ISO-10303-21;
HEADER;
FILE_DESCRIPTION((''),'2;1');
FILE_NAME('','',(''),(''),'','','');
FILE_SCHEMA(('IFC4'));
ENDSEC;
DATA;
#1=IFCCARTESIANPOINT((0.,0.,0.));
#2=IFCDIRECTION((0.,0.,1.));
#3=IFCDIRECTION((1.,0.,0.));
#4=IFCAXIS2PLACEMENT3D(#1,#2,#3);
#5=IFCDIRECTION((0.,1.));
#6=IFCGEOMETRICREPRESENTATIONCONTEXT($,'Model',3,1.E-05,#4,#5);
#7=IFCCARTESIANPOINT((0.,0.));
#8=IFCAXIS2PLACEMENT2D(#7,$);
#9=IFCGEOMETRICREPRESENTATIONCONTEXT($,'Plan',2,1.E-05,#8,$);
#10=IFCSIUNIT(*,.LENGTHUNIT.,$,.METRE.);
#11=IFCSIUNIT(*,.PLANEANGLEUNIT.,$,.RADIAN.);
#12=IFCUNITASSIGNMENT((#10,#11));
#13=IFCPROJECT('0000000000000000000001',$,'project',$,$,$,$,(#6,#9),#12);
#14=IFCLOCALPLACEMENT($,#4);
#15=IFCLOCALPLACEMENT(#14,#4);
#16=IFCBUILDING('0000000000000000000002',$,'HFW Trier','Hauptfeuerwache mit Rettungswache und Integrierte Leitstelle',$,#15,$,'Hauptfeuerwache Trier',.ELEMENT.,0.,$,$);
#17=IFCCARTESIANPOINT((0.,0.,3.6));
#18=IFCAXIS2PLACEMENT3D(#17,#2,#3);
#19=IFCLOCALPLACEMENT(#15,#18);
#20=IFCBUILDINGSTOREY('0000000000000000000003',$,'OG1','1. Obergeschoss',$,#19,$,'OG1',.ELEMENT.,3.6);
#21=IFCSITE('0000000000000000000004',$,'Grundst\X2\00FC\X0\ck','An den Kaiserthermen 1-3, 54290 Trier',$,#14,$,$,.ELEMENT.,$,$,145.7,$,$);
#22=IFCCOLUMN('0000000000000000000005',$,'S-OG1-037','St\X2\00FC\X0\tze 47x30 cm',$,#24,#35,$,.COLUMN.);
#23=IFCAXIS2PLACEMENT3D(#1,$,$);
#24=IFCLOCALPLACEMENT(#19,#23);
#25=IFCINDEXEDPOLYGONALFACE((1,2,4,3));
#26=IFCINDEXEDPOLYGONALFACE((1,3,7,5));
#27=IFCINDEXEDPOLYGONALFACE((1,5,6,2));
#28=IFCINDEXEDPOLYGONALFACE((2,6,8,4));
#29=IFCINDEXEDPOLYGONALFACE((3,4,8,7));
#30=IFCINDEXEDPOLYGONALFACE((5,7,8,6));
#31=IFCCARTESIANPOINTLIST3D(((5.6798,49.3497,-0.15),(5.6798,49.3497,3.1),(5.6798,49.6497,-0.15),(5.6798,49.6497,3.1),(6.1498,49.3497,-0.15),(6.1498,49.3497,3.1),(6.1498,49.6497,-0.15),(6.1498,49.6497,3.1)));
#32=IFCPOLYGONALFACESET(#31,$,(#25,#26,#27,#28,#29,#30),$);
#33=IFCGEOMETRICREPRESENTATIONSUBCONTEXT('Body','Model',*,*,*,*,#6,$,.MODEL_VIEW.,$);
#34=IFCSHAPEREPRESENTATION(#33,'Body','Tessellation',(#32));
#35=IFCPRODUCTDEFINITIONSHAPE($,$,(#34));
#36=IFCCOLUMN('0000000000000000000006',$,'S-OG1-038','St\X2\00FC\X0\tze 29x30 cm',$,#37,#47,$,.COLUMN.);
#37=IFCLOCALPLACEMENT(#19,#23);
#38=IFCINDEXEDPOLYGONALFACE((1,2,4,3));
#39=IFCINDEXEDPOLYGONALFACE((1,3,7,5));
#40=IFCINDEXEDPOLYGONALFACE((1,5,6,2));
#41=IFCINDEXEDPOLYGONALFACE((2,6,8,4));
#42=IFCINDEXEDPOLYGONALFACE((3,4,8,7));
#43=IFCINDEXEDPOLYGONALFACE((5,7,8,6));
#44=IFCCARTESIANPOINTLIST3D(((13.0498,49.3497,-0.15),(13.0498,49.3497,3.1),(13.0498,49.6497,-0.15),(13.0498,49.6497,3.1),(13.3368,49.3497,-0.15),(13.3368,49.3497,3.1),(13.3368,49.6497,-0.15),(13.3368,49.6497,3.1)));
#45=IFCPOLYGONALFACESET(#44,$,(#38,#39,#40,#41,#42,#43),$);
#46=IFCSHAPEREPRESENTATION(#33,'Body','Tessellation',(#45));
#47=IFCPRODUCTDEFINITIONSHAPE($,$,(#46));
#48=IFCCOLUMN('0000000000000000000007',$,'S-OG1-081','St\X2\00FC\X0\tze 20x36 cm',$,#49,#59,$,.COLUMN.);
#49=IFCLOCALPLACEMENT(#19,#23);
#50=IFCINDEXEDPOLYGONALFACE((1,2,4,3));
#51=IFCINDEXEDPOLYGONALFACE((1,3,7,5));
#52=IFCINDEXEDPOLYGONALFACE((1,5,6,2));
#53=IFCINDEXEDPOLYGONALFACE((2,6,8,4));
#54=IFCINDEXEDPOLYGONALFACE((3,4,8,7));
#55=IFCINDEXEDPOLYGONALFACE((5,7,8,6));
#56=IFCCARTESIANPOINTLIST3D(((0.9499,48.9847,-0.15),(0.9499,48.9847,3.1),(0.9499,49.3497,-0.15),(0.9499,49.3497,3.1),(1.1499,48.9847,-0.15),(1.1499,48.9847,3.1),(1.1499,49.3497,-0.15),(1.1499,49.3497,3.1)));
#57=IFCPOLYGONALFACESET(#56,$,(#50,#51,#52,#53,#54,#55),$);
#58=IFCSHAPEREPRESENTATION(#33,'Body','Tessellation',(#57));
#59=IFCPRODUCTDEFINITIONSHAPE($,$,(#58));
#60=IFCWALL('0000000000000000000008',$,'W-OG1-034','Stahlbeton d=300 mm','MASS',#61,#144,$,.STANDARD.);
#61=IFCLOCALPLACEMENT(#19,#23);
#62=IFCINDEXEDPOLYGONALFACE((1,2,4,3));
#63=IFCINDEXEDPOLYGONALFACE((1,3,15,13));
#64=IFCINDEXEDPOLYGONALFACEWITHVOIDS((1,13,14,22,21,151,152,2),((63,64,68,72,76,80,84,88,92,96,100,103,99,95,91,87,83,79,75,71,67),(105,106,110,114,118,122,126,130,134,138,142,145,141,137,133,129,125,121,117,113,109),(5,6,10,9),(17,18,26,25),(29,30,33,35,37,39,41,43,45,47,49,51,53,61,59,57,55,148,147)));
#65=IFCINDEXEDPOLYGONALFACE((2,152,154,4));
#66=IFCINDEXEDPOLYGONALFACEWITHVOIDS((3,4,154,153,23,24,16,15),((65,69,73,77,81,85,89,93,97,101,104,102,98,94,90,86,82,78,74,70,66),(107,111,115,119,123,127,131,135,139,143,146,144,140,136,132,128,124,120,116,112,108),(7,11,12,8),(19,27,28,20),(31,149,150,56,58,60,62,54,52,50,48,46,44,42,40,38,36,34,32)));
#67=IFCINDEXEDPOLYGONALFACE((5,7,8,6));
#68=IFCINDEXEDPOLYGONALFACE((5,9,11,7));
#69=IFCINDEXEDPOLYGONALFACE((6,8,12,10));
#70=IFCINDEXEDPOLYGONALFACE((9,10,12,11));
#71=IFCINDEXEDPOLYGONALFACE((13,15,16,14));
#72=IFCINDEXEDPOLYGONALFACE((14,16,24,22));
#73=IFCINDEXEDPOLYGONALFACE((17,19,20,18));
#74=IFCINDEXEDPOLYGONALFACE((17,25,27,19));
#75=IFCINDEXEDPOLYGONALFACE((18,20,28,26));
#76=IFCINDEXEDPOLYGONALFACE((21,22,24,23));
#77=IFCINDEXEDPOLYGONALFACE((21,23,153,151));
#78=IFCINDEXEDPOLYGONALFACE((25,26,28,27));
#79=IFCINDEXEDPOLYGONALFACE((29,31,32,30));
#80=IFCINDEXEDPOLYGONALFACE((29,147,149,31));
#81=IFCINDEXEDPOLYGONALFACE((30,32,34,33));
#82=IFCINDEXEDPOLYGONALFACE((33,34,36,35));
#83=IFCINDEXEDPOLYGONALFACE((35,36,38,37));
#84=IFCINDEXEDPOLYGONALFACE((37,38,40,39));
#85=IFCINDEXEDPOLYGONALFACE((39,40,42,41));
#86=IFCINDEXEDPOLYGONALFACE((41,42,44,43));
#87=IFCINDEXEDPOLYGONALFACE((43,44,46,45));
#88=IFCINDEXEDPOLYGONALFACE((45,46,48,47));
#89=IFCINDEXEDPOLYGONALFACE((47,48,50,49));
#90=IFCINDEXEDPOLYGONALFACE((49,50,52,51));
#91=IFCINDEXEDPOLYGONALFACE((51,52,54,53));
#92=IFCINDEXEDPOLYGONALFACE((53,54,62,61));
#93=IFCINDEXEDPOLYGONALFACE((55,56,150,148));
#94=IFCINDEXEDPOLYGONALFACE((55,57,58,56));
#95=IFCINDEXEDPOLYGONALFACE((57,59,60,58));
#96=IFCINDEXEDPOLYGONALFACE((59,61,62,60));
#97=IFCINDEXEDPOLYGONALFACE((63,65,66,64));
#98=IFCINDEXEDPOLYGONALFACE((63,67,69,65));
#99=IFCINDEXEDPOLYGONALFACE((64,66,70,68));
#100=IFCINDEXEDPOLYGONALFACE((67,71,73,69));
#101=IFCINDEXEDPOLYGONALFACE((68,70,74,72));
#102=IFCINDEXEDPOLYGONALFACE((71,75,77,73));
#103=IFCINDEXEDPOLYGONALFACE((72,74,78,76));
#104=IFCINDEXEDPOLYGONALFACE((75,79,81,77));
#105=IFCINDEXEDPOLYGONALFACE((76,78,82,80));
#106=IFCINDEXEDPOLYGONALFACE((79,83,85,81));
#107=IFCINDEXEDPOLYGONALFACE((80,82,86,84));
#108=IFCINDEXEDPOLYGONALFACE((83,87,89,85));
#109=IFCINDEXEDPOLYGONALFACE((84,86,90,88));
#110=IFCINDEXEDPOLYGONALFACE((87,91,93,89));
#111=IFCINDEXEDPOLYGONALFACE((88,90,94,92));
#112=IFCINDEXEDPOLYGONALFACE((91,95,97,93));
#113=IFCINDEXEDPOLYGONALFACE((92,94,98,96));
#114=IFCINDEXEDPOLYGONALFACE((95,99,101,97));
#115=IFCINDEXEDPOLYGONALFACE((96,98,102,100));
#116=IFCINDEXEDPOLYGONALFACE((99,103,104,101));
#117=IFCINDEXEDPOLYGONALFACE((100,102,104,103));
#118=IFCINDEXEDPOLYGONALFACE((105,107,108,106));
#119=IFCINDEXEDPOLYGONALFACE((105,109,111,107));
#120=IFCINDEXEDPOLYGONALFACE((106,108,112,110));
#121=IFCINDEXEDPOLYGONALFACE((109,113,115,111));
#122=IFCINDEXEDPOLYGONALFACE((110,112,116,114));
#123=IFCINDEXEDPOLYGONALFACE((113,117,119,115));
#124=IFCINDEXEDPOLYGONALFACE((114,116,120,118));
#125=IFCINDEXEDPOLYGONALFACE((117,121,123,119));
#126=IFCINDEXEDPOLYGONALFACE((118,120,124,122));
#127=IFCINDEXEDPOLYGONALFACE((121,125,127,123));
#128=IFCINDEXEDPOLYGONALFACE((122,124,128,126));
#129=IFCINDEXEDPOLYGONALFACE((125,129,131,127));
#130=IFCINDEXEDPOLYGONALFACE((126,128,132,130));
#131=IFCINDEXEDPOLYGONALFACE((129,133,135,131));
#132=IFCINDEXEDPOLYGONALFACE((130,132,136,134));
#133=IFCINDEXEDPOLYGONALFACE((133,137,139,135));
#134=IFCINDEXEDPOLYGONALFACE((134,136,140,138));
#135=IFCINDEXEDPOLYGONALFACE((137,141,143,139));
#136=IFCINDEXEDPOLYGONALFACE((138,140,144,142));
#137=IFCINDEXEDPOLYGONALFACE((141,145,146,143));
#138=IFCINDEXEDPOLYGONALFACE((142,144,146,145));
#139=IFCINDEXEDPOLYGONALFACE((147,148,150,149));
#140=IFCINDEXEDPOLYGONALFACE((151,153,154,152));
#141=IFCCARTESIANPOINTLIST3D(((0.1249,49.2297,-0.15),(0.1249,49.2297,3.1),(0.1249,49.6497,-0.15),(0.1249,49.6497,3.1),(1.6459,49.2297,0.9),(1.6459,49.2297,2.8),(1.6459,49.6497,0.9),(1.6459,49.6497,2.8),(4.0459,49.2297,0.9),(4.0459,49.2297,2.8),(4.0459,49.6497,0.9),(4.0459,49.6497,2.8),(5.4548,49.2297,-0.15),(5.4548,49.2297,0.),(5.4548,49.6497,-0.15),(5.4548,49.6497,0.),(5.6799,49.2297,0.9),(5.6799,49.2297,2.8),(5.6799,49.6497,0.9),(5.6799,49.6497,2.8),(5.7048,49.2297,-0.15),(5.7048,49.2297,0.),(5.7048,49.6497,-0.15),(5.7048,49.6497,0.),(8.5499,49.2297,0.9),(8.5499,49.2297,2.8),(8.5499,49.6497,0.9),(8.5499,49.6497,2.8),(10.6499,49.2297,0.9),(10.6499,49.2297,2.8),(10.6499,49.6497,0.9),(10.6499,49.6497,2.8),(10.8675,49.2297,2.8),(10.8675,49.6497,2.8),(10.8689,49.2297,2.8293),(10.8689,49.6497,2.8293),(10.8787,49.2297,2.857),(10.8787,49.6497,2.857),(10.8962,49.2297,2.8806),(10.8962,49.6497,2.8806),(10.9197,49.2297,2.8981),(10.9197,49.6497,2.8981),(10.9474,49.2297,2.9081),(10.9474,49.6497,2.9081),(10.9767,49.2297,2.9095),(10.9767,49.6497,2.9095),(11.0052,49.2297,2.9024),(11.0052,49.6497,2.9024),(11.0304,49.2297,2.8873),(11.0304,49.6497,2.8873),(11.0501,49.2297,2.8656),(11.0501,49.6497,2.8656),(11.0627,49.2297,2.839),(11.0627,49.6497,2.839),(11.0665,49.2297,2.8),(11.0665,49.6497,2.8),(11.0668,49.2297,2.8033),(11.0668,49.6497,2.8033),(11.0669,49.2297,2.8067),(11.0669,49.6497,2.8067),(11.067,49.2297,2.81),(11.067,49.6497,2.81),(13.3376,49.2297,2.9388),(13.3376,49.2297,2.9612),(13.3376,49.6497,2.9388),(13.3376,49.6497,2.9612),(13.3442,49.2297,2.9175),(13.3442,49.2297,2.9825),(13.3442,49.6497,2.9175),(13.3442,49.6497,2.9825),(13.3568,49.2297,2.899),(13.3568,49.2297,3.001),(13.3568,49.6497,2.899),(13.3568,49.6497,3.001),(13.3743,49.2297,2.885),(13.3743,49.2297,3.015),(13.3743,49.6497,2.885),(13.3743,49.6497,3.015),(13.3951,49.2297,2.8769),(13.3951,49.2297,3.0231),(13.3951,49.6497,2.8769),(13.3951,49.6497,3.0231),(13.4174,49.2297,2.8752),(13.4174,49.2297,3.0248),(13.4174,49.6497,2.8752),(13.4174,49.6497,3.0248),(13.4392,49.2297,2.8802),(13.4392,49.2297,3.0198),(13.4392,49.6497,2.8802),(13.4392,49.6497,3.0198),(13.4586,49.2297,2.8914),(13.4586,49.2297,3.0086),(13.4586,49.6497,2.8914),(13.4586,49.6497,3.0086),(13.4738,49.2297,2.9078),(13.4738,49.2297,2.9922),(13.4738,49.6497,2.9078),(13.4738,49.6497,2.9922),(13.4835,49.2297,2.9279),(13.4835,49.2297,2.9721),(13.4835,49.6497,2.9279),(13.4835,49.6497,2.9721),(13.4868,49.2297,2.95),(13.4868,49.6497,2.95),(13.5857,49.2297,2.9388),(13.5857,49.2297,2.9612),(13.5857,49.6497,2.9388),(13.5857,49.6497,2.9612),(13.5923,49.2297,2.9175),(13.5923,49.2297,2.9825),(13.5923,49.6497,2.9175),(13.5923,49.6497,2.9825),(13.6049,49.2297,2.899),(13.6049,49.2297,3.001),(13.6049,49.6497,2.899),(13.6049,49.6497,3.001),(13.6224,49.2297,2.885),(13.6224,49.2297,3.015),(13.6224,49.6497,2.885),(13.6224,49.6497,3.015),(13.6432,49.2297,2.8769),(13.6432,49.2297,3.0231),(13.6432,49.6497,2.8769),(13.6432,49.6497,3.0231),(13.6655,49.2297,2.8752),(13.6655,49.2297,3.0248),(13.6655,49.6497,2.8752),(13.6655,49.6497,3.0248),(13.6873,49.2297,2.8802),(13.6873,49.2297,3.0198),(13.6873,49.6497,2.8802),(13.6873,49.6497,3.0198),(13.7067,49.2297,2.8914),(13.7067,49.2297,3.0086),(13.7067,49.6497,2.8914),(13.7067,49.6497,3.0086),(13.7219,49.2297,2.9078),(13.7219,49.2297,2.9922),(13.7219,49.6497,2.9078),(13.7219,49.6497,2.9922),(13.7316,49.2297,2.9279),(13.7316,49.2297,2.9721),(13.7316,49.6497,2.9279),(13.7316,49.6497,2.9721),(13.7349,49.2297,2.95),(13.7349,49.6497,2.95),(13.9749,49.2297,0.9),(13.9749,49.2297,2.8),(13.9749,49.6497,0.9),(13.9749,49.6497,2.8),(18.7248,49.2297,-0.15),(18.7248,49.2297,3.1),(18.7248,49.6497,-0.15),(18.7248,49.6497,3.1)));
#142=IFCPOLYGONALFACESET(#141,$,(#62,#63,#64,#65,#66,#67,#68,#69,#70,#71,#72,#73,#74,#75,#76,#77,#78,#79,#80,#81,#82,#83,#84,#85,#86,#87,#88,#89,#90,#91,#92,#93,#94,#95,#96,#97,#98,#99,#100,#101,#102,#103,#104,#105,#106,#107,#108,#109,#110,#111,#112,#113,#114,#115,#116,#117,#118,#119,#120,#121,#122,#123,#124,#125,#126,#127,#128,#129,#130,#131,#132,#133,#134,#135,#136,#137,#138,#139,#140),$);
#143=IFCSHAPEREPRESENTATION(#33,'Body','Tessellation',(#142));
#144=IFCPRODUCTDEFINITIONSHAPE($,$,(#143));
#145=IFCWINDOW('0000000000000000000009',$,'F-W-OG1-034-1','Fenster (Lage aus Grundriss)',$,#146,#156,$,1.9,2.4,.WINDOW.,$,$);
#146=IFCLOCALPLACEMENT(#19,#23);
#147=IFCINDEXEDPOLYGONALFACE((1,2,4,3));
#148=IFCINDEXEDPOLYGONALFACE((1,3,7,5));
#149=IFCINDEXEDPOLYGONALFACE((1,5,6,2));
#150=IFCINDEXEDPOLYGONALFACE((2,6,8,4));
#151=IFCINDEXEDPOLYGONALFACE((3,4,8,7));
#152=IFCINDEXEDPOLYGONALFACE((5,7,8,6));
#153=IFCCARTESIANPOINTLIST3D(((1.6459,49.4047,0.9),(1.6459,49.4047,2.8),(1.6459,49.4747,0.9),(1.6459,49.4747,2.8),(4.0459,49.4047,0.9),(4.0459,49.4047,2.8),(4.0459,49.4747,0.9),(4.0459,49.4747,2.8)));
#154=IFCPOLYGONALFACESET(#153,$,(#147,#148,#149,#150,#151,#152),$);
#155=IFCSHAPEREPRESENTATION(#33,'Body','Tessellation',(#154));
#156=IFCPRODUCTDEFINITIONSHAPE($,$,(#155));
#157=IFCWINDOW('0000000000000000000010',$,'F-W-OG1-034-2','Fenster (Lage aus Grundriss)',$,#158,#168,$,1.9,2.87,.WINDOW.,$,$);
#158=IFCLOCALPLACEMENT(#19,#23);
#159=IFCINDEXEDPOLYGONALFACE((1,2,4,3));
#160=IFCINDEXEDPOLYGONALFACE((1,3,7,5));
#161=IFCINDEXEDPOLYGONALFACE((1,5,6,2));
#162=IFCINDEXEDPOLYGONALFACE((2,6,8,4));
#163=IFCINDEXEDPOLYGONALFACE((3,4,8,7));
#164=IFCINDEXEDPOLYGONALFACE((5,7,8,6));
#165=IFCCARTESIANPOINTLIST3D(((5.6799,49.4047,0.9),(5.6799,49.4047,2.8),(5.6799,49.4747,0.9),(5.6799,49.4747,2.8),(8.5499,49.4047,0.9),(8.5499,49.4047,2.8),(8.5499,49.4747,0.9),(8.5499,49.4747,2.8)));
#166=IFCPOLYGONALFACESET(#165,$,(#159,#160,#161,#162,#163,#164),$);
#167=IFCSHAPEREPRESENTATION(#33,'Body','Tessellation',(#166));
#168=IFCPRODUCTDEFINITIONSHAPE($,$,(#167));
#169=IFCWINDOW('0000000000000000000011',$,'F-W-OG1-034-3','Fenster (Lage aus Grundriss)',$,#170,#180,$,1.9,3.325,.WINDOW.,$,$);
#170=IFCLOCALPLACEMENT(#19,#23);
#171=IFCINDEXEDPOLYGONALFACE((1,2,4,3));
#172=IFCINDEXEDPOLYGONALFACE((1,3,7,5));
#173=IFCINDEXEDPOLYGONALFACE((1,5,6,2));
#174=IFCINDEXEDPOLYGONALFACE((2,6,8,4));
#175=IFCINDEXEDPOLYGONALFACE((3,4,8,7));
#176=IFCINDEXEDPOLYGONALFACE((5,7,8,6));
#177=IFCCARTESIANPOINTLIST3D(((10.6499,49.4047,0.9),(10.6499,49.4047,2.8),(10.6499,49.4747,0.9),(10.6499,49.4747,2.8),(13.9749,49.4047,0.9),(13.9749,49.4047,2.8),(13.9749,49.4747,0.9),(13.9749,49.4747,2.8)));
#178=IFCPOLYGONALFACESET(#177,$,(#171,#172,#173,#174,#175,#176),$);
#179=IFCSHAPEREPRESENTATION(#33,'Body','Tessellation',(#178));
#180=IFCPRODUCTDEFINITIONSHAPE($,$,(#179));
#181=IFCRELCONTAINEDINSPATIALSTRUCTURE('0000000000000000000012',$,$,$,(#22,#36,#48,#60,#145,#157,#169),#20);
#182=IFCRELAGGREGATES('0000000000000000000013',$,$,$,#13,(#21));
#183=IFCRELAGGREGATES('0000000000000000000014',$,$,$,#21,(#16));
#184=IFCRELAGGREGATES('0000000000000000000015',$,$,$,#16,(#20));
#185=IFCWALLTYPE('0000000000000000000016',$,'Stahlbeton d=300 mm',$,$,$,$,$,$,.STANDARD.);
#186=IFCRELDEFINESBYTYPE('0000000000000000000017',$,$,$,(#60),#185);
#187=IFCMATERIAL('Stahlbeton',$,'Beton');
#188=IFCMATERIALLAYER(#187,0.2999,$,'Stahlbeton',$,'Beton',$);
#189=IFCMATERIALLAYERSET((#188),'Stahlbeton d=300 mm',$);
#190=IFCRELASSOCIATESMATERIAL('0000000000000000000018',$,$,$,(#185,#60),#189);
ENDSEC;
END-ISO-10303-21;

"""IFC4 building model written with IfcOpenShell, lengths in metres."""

from ifc_helpers import new_model, si_unit, direction, frame, frame_2d, origin_with_axes, origin_2d, place, context, subcontext, project, spatial, rectangle, circle, extrude, material, layer, layer_set, layer_usage, type_object, element, fill, save


model = new_model("IFC4")

# Units and contexts
model_context = context("Model", 3, precision=1e-05, world=origin_with_axes(), true_north=direction((0.0, 1.0)))
plan_context = context("Plan", 2, precision=1e-05, world=origin_2d())
body_context = subcontext(model_context, "Body", "Model", "MODEL_VIEW")
ifc_project = project(units=[si_unit("LENGTHUNIT", "METRE"), si_unit("PLANEANGLEUNIT", "RADIAN")], contexts=[model_context, plan_context])

# Site, building, storey
site_placement = place(None, origin_with_axes())
site = spatial("IfcSite", under=ifc_project, at=site_placement, Name="Grundstück", Description="An den Kaiserthermen 1-3, 54290 Trier", CompositionType="ELEMENT", RefElevation=145.7)
building_placement = place(site_placement, origin_with_axes())
building = spatial("IfcBuilding", under=site, at=building_placement, Name="HFW Trier", Description="Hauptfeuerwache mit Rettungswache und Integrierte Leitstelle", LongName="Hauptfeuerwache Trier", CompositionType="ELEMENT", ElevationOfRefHeight=0.0)
storey_placement = place(building_placement, frame((0.0, 0.0, 3.6), z_axis=(0.0, 0.0, 1.0), x_axis=(1.0, 0.0, 0.0)))
storey = spatial("IfcBuildingStorey", under=building, at=storey_placement, Name="OG1", Description="1. Obergeschoss", LongName="OG1", CompositionType="ELEMENT", Elevation=3.6)

# Columns
column_1_placement = place(storey_placement, frame((5.6798, 49.4997, -0.15), z_axis=(0.0, 0.0, 1.0), x_axis=(1.0, 0.0, 0.0)))
element("IfcColumn", 1, at=column_1_placement, inside=storey, Name="S-OG1-037", Description="Stütze 47x30 cm", PredefinedType="COLUMN", context=body_context, shape_type="SweptSolid", body=[
    extrude(rectangle(XDim=0.47, YDim=0.3, at=frame_2d((0.235, 0.0))), origin_with_axes(), (0.0, 0.0, 1.0), 3.25),
])
column_2_placement = place(storey_placement, frame((13.0498, 49.4997, -0.15), z_axis=(0.0, 0.0, 1.0), x_axis=(1.0, 0.0, 0.0)))
element("IfcColumn", 2, at=column_2_placement, inside=storey, Name="S-OG1-038", Description="Stütze 29x30 cm", PredefinedType="COLUMN", context=body_context, shape_type="SweptSolid", body=[
    extrude(rectangle(XDim=0.287, YDim=0.3, at=frame_2d((0.1435, 0.0))), origin_with_axes(), (0.0, 0.0, 1.0), 3.25),
])
column_3_placement = place(storey_placement, frame((0.9499, 49.1672, -0.15), z_axis=(0.0, 0.0, 1.0), x_axis=(1.0, 0.0, 0.0)))
element("IfcColumn", 3, at=column_3_placement, inside=storey, Name="S-OG1-081", Description="Stütze 20x36 cm", PredefinedType="COLUMN", context=body_context, shape_type="SweptSolid", body=[
    extrude(rectangle(XDim=0.2, YDim=0.365, at=frame_2d((0.1, 0.0))), origin_with_axes(), (0.0, 0.0, 1.0), 3.25),
])

# Wall, openings, windows
ifc_material_1 = material(Name="Stahlbeton", Category="Beton")
ifc_layer_1 = layer(ifc_material_1, 0.2999, Name="Stahlbeton", Category="Beton")
ifc_layer_set_1 = layer_set([ifc_layer_1], Name="Stahlbeton d=300 mm")
ifc_layer_usage_1 = layer_usage(ifc_layer_set_1, "AXIS2", "POSITIVE", -0.21)
wall_type_1 = type_object("IfcWallType", Name="Stahlbeton d=300 mm", PredefinedType="STANDARD", material=ifc_layer_set_1)
wall_1_placement = place(storey_placement, frame((0.1249, 49.4397, -0.15), z_axis=(0.0, 0.0, 1.0), x_axis=(1.0, 0.0, 0.0)))
wall_1 = element("IfcWall", 4, at=wall_1_placement, inside=storey, type_object=wall_type_1, material=ifc_layer_usage_1, Name="W-OG1-034", Description="Stahlbeton d=300 mm", ObjectType="MASS", PredefinedType="STANDARD", context=body_context, shape_type="SweptSolid", body=[
    extrude(rectangle(XDim=18.5999, YDim=0.42, at=frame_2d((9.2999, 0.0))), origin_with_axes(), (0.0, 0.0, 1.0), 3.25),
])
opening_1_placement = place(wall_1_placement, frame((1.521, 0.0, 0.0), z_axis=(0.0, 0.0, 1.0), x_axis=(1.0, 0.0, 0.0)))
opening_1 = element("IfcOpeningElement", 5, at=opening_1_placement, cuts=wall_1, PredefinedType="OPENING", context=body_context, shape_type="SweptSolid", body=[
    extrude(rectangle(XDim=2.4, YDim=0.52, at=frame_2d((1.2, 0.0))), frame((0.0, 0.0, 1.05), z_axis=(0.0, 0.0, 1.0), x_axis=(1.0, 0.0, 0.0)), (0.0, 0.0, 1.0), 1.9),
])
opening_2_placement = place(wall_1_placement, frame((5.555, 0.0, 0.0), z_axis=(0.0, 0.0, 1.0), x_axis=(1.0, 0.0, 0.0)))
opening_2 = element("IfcOpeningElement", 6, at=opening_2_placement, cuts=wall_1, PredefinedType="OPENING", context=body_context, shape_type="SweptSolid", body=[
    extrude(rectangle(XDim=2.87, YDim=0.52, at=frame_2d((1.435, 0.0))), frame((0.0, 0.0, 1.05), z_axis=(0.0, 0.0, 1.0), x_axis=(1.0, 0.0, 0.0)), (0.0, 0.0, 1.0), 1.9),
])
opening_3_placement = place(wall_1_placement, frame((10.525, 0.0, 0.0), z_axis=(0.0, 0.0, 1.0), x_axis=(1.0, 0.0, 0.0)))
opening_3 = element("IfcOpeningElement", 7, at=opening_3_placement, cuts=wall_1, PredefinedType="OPENING", context=body_context, shape_type="SweptSolid", body=[
    extrude(rectangle(XDim=3.325, YDim=0.52, at=frame_2d((1.6625, 0.0))), frame((0.0, 0.0, 1.05), z_axis=(0.0, 0.0, 1.0), x_axis=(1.0, 0.0, 0.0)), (0.0, 0.0, 1.0), 1.9),
])
opening_4_placement = place(wall_1_placement, origin_with_axes())
element("IfcOpeningElement", 8, at=opening_4_placement, cuts=wall_1, ObjectType="Wanddurchbruch", PredefinedType="OPENING", context=body_context, shape_type="SweptSolid", body=[
    extrude(circle(Radius=0.1, at=origin_2d()), frame((10.8421, -0.26, 2.96), z_axis=(0.0, 1.0, 0.0), x_axis=(1.0, 0.0, 0.0)), (0.0, 0.0, 1.0), 0.52),
])
opening_5_placement = place(wall_1_placement, origin_with_axes())
element("IfcOpeningElement", 9, at=opening_5_placement, cuts=wall_1, ObjectType="Wanddurchbruch", PredefinedType="OPENING", context=body_context, shape_type="SweptSolid", body=[
    extrude(circle(Radius=0.075, at=origin_2d()), frame((13.2869, -0.26, 3.1), z_axis=(0.0, 1.0, 0.0), x_axis=(1.0, 0.0, 0.0)), (0.0, 0.0, 1.0), 0.52),
])
opening_6_placement = place(wall_1_placement, origin_with_axes())
element("IfcOpeningElement", 10, at=opening_6_placement, cuts=wall_1, ObjectType="Wanddurchbruch", PredefinedType="OPENING", context=body_context, shape_type="SweptSolid", body=[
    extrude(circle(Radius=0.075, at=origin_2d()), frame((13.535, -0.26, 3.1), z_axis=(0.0, 1.0, 0.0), x_axis=(1.0, 0.0, 0.0)), (0.0, 0.0, 1.0), 0.52),
])
opening_7_placement = place(wall_1_placement, origin_with_axes())
element("IfcOpeningElement", 11, at=opening_7_placement, cuts=wall_1, ObjectType="Wanddurchbruch", PredefinedType="OPENING", context=body_context, shape_type="SweptSolid", body=[
    extrude(rectangle(XDim=0.25, YDim=0.52, at=frame_2d((5.4549, 0.0))), origin_with_axes(), (0.0, 0.0, 1.0), 0.15),
])
window_1_placement = place(wall_1_placement, frame((1.521, 0.0, 0.0), z_axis=(0.0, 0.0, 1.0), x_axis=(1.0, 0.0, 0.0)))
window_1 = element("IfcWindow", 12, at=window_1_placement, inside=storey, Name="F-W-OG1-034-1", Description="Fenster (Lage aus Grundriss)", OverallHeight=1.9, OverallWidth=2.4, PredefinedType="WINDOW", context=body_context, shape_type="SweptSolid", body=[
    extrude(rectangle(XDim=2.4, YDim=0.07, at=frame_2d((1.2, 0.0))), frame((0.0, 0.0, 1.05), z_axis=(0.0, 0.0, 1.0), x_axis=(1.0, 0.0, 0.0)), (0.0, 0.0, 1.0), 1.9),
])
fill(opening_1, window_1)
window_2_placement = place(wall_1_placement, frame((5.555, 0.0, 0.0), z_axis=(0.0, 0.0, 1.0), x_axis=(1.0, 0.0, 0.0)))
window_2 = element("IfcWindow", 13, at=window_2_placement, inside=storey, Name="F-W-OG1-034-2", Description="Fenster (Lage aus Grundriss)", OverallHeight=1.9, OverallWidth=2.87, PredefinedType="WINDOW", context=body_context, shape_type="SweptSolid", body=[
    extrude(rectangle(XDim=2.87, YDim=0.07, at=frame_2d((1.435, 0.0))), frame((0.0, 0.0, 1.05), z_axis=(0.0, 0.0, 1.0), x_axis=(1.0, 0.0, 0.0)), (0.0, 0.0, 1.0), 1.9),
])
fill(opening_2, window_2)
window_3_placement = place(wall_1_placement, frame((10.525, 0.0, 0.0), z_axis=(0.0, 0.0, 1.0), x_axis=(1.0, 0.0, 0.0)))
window_3 = element("IfcWindow", 14, at=window_3_placement, inside=storey, Name="F-W-OG1-034-3", Description="Fenster (Lage aus Grundriss)", OverallHeight=1.9, OverallWidth=3.325, PredefinedType="WINDOW", context=body_context, shape_type="SweptSolid", body=[
    extrude(rectangle(XDim=3.325, YDim=0.07, at=frame_2d((1.6625, 0.0))), frame((0.0, 0.0, 1.05), z_axis=(0.0, 0.0, 1.0), x_axis=(1.0, 0.0, 0.0)), (0.0, 0.0, 1.0), 1.9),
])
fill(opening_3, window_3)

save(model, "model.ifc")
